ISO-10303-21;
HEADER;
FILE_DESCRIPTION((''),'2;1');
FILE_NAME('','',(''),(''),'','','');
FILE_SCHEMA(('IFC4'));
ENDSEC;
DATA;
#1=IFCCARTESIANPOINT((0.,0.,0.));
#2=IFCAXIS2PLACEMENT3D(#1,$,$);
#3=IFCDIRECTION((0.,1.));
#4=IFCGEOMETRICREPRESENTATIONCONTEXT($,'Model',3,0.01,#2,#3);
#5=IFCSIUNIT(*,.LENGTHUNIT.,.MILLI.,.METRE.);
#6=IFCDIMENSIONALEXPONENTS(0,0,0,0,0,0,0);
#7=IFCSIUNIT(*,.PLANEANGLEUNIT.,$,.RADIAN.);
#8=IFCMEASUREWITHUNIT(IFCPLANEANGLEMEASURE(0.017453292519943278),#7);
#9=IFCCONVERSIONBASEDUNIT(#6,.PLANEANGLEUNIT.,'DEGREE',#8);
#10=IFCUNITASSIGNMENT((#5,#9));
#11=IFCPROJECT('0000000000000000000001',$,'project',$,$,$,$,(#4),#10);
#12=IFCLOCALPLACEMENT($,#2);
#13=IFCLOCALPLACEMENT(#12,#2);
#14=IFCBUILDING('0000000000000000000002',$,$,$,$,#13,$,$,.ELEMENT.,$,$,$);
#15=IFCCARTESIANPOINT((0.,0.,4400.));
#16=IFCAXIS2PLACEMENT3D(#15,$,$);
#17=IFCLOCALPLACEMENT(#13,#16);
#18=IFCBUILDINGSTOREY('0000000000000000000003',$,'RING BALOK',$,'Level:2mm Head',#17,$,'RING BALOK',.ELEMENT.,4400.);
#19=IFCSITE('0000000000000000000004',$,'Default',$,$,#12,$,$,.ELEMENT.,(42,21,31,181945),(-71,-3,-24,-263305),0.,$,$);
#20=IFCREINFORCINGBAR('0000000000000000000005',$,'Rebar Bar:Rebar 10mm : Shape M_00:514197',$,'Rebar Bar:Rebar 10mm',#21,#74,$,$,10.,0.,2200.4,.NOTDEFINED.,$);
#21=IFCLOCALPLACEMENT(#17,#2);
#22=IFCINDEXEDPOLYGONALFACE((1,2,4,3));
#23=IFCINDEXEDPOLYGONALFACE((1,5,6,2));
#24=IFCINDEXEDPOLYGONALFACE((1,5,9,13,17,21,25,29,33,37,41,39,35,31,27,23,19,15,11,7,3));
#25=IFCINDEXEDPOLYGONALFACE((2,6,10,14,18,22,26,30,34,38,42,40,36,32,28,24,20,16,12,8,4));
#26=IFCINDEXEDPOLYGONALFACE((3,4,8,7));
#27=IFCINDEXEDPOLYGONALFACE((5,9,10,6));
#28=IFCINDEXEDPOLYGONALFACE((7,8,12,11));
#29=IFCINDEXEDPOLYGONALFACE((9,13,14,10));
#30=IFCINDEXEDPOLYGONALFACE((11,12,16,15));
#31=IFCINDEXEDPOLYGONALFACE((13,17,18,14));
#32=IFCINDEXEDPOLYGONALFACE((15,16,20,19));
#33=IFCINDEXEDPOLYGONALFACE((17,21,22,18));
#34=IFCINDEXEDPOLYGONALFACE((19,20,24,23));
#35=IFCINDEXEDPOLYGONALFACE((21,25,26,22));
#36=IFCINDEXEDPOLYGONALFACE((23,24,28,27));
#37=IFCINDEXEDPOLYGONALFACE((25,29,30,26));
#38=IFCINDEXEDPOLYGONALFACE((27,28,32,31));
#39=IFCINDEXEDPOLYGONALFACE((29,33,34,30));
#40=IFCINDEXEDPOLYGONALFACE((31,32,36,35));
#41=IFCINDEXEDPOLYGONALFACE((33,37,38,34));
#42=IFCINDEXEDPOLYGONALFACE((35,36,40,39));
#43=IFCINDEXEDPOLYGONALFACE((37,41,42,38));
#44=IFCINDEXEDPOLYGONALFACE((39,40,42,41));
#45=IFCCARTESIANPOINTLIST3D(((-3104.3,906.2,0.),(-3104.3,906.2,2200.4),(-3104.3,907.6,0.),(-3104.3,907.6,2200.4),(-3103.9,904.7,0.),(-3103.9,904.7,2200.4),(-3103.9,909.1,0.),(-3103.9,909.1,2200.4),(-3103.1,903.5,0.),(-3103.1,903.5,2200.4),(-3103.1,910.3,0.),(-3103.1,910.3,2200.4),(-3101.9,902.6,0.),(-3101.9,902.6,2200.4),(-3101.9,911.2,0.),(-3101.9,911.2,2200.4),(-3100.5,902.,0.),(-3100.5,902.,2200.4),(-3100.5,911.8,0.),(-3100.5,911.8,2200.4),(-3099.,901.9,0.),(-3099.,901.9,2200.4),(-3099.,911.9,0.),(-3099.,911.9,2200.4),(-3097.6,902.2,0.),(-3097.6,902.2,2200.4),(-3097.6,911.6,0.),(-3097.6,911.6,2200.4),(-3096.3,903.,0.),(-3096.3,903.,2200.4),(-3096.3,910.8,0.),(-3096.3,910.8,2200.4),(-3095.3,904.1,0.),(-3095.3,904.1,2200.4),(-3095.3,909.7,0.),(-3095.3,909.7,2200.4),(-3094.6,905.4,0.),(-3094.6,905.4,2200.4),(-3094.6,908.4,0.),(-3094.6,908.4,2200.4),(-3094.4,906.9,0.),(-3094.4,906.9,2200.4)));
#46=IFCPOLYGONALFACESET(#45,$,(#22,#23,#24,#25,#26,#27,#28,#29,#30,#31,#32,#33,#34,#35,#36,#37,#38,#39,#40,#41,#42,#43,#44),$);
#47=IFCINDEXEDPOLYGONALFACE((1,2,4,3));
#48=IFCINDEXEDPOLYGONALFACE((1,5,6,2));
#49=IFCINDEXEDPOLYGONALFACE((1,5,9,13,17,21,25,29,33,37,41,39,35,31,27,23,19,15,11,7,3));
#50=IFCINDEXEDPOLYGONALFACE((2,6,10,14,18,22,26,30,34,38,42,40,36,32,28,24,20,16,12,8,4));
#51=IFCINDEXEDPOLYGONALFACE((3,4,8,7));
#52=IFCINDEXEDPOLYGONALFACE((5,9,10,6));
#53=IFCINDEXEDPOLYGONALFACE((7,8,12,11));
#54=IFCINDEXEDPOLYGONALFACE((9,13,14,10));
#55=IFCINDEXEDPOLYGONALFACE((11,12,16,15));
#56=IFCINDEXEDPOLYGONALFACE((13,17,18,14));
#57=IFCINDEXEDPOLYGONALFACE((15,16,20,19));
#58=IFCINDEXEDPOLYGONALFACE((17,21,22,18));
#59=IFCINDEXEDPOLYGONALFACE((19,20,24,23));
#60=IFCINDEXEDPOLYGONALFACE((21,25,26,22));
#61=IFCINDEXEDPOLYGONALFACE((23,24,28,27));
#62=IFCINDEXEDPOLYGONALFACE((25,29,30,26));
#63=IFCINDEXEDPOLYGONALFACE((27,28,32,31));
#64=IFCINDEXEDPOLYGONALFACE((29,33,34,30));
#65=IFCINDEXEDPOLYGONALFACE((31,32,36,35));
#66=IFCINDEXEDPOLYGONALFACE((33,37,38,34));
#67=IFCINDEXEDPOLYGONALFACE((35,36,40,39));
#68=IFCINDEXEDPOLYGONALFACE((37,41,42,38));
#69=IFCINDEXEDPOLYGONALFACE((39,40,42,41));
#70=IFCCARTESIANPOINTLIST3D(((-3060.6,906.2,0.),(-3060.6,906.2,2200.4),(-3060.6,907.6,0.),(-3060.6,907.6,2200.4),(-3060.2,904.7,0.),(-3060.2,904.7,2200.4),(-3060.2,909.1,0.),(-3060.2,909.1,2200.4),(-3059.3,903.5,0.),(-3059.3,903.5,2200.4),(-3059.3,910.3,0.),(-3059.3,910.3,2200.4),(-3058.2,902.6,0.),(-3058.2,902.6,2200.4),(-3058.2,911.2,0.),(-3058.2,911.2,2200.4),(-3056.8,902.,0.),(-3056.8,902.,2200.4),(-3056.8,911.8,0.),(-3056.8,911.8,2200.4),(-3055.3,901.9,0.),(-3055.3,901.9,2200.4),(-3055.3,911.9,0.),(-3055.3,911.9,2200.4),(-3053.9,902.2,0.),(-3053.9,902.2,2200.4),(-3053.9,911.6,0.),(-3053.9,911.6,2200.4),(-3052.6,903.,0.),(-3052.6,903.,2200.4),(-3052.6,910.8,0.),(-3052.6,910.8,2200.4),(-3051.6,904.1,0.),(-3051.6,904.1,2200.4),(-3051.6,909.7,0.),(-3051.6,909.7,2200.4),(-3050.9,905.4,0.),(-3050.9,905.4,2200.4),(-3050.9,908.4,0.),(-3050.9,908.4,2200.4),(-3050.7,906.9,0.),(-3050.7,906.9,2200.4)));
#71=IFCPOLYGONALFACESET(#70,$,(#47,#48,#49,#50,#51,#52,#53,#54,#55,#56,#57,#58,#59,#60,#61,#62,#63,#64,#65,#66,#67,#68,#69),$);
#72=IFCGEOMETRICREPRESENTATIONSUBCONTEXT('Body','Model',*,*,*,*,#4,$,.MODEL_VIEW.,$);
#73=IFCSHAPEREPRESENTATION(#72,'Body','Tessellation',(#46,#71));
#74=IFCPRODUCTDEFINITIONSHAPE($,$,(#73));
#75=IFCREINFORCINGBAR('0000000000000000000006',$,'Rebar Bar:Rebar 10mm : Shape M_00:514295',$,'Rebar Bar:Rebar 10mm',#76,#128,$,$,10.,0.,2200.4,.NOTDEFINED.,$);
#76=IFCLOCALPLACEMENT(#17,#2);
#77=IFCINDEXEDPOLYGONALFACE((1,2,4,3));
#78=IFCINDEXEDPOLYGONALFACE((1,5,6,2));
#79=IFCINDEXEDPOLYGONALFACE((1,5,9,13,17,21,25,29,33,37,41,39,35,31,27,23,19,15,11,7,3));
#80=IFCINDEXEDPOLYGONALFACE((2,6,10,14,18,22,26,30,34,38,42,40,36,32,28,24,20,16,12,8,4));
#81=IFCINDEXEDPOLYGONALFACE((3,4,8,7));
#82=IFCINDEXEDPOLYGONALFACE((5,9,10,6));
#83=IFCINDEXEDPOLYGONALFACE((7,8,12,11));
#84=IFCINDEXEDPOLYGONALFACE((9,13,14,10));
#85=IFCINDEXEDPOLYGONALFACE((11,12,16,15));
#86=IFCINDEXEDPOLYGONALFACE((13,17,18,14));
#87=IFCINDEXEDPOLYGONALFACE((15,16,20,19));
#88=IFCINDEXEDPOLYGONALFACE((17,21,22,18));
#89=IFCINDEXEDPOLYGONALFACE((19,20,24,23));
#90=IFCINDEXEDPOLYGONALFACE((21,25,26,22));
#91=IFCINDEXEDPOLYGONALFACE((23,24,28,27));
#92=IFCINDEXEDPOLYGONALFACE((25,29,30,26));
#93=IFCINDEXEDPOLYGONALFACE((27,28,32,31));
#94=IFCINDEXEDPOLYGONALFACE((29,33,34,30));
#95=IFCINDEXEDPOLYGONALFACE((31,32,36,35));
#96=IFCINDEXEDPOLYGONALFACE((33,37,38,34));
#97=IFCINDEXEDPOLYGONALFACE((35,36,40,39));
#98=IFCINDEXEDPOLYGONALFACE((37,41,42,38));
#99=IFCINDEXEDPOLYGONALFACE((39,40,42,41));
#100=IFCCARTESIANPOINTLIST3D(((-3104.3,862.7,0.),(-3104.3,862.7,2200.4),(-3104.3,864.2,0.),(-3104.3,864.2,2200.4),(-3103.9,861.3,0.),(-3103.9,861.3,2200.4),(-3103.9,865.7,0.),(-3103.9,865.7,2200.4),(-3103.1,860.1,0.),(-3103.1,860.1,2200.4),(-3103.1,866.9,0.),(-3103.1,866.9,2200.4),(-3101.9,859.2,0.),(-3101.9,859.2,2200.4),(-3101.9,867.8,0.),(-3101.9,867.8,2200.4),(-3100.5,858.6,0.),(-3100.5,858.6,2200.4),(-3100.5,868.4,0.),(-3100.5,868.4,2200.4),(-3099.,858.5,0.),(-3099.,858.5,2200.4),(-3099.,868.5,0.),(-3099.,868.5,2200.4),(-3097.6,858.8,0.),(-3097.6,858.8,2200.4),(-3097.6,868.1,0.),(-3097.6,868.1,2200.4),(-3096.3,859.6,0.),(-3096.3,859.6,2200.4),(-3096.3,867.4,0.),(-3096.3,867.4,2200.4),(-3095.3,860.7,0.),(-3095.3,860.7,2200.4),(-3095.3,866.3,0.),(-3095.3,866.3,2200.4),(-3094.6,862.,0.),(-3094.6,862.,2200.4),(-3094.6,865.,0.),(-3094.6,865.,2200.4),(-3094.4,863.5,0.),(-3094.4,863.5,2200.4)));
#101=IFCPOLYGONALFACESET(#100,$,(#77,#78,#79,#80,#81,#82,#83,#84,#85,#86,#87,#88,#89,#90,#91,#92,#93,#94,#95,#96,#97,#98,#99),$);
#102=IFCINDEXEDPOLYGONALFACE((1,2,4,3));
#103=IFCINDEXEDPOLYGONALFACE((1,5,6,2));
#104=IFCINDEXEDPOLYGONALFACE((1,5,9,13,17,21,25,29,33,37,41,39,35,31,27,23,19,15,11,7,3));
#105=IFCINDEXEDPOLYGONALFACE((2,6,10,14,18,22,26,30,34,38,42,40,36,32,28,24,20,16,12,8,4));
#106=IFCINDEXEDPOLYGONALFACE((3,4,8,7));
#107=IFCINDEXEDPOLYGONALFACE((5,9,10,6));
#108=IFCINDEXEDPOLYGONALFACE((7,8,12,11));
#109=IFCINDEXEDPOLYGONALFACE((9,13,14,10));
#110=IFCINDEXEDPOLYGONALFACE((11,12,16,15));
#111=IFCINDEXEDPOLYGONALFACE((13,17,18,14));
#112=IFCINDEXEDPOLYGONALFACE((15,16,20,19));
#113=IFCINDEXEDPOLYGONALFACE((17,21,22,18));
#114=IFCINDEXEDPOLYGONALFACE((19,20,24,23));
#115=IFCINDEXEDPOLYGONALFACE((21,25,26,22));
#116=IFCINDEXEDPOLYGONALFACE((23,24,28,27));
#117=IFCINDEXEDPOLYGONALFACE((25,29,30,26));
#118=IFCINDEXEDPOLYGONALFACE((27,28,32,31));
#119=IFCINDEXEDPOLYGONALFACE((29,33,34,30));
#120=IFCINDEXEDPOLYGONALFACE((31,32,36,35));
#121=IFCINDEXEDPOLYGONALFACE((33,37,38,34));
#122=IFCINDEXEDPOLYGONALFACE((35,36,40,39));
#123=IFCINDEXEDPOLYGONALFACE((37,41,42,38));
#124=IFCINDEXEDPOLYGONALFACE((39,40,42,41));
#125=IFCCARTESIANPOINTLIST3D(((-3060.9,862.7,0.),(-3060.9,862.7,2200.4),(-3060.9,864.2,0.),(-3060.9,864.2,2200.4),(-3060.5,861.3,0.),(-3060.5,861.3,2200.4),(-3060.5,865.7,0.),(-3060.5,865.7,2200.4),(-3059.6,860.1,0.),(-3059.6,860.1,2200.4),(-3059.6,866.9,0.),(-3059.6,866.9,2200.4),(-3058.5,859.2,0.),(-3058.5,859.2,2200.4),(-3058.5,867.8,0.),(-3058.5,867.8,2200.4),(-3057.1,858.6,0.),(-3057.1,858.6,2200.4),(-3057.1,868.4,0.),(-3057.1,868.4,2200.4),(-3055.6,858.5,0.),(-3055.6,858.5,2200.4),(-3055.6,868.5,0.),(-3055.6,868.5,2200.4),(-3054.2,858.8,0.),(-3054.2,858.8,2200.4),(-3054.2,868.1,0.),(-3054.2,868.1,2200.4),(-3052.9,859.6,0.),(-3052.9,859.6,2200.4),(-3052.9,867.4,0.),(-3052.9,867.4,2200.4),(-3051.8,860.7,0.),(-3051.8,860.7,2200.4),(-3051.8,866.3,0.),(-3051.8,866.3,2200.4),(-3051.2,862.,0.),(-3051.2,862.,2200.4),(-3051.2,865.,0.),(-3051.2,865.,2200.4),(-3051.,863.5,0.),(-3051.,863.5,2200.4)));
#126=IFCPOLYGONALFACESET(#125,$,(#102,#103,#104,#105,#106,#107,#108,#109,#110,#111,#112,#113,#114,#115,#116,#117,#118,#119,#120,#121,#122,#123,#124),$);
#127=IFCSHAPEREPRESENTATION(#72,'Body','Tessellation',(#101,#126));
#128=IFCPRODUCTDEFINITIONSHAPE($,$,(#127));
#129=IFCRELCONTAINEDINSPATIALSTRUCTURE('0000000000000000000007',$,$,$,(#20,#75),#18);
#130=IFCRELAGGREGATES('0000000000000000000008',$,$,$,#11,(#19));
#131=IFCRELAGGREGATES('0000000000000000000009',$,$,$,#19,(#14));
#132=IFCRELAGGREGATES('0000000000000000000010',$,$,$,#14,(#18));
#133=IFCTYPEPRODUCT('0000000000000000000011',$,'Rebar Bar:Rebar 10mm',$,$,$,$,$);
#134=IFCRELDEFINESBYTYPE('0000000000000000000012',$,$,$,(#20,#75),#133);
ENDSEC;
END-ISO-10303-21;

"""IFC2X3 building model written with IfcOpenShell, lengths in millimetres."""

from ifc_helpers import new_model, entity, si_unit, converted_unit, direction, frame, origin, place, context, subcontext, project, spatial, type_object, element, save


model = new_model("IFC2X3")

# Units and contexts
model_context = context("Model", 3, precision=0.01, world=origin(), true_north=direction((0.0, 1.0)))
body_context = subcontext(model_context, "Body", "Model", "MODEL_VIEW")
ifc_project = project(units=[si_unit("LENGTHUNIT", "METRE", prefix="MILLI"), converted_unit("PLANEANGLEUNIT", "DEGREE", entity("IfcPlaneAngleMeasure", 0.017453292519943278), si_unit("PLANEANGLEUNIT", "RADIAN"), dimensions=[0, 0, 0, 0, 0, 0, 0])], contexts=[model_context])

# Site, building, storey
site_placement = place(None, origin())
site = spatial("IfcSite", under=ifc_project, at=site_placement, Name="Default", CompositionType="ELEMENT", RefLatitude=(42, 21, 31, 181945), RefLongitude=(-71, -3, -24, -263305), RefElevation=0.0)
building_placement = place(site_placement, origin())
building = spatial("IfcBuilding", under=site, at=building_placement, CompositionType="ELEMENT")
storey_placement = place(building_placement, frame((0.0, 0.0, 4400.0)))
storey = spatial("IfcBuildingStorey", under=building, at=storey_placement, Name="RING BALOK", ObjectType="Level:2mm Head", LongName="RING BALOK", CompositionType="ELEMENT", Elevation=4400.0)

# Reinforcing bars
type_product_1 = type_object("IfcTypeProduct", Name="Rebar Bar:Rebar 10mm")
reinforcing_bar_1_placement = place(storey_placement, origin())
element("IfcReinforcingBar", 1, at=reinforcing_bar_1_placement, inside=storey, type_object=type_product_1, Name="Rebar Bar:Rebar 10mm : Shape M_00:514197", ObjectType="Rebar Bar:Rebar 10mm", BarLength=2200.4, BarRole="NOTDEFINED", CrossSectionArea=0.0, NominalDiameter=10.0, context=body_context, shape_type="AdvancedSweptSolid", body=[
    entity("IfcSweptDiskSolid", entity("IfcCompositeCurve", [entity("IfcCompositeCurveSegment", "CONTINUOUS", True, entity("IfcPolyline", [entity("IfcCartesianPoint", [-3099.4, 906.9, 0.0]), entity("IfcCartesianPoint", [-3099.4, 906.9, 2200.4])]))], False), 5.0, None, 0.0, 1.0),
    entity("IfcSweptDiskSolid", entity("IfcCompositeCurve", [entity("IfcCompositeCurveSegment", "CONTINUOUS", True, entity("IfcPolyline", [entity("IfcCartesianPoint", [-3055.7, 906.9, 0.0]), entity("IfcCartesianPoint", [-3055.7, 906.9, 2200.4])]))], False), 5.0, None, 0.0, 1.0),
])
reinforcing_bar_2_placement = place(storey_placement, origin())
element("IfcReinforcingBar", 2, at=reinforcing_bar_2_placement, inside=storey, type_object=type_product_1, Name="Rebar Bar:Rebar 10mm : Shape M_00:514295", ObjectType="Rebar Bar:Rebar 10mm", BarLength=2200.4, BarRole="NOTDEFINED", CrossSectionArea=0.0, NominalDiameter=10.0, context=body_context, shape_type="AdvancedSweptSolid", body=[
    entity("IfcSweptDiskSolid", entity("IfcCompositeCurve", [entity("IfcCompositeCurveSegment", "CONTINUOUS", True, entity("IfcPolyline", [entity("IfcCartesianPoint", [-3099.4, 863.5, 0.0]), entity("IfcCartesianPoint", [-3099.4, 863.5, 2200.4])]))], False), 5.0, None, 0.0, 1.0),
    entity("IfcSweptDiskSolid", entity("IfcCompositeCurve", [entity("IfcCompositeCurveSegment", "CONTINUOUS", True, entity("IfcPolyline", [entity("IfcCartesianPoint", [-3056.0, 863.5, 0.0]), entity("IfcCartesianPoint", [-3056.0, 863.5, 2200.4])]))], False), 5.0, None, 0.0, 1.0),
])

save(model, "model.ifc")
